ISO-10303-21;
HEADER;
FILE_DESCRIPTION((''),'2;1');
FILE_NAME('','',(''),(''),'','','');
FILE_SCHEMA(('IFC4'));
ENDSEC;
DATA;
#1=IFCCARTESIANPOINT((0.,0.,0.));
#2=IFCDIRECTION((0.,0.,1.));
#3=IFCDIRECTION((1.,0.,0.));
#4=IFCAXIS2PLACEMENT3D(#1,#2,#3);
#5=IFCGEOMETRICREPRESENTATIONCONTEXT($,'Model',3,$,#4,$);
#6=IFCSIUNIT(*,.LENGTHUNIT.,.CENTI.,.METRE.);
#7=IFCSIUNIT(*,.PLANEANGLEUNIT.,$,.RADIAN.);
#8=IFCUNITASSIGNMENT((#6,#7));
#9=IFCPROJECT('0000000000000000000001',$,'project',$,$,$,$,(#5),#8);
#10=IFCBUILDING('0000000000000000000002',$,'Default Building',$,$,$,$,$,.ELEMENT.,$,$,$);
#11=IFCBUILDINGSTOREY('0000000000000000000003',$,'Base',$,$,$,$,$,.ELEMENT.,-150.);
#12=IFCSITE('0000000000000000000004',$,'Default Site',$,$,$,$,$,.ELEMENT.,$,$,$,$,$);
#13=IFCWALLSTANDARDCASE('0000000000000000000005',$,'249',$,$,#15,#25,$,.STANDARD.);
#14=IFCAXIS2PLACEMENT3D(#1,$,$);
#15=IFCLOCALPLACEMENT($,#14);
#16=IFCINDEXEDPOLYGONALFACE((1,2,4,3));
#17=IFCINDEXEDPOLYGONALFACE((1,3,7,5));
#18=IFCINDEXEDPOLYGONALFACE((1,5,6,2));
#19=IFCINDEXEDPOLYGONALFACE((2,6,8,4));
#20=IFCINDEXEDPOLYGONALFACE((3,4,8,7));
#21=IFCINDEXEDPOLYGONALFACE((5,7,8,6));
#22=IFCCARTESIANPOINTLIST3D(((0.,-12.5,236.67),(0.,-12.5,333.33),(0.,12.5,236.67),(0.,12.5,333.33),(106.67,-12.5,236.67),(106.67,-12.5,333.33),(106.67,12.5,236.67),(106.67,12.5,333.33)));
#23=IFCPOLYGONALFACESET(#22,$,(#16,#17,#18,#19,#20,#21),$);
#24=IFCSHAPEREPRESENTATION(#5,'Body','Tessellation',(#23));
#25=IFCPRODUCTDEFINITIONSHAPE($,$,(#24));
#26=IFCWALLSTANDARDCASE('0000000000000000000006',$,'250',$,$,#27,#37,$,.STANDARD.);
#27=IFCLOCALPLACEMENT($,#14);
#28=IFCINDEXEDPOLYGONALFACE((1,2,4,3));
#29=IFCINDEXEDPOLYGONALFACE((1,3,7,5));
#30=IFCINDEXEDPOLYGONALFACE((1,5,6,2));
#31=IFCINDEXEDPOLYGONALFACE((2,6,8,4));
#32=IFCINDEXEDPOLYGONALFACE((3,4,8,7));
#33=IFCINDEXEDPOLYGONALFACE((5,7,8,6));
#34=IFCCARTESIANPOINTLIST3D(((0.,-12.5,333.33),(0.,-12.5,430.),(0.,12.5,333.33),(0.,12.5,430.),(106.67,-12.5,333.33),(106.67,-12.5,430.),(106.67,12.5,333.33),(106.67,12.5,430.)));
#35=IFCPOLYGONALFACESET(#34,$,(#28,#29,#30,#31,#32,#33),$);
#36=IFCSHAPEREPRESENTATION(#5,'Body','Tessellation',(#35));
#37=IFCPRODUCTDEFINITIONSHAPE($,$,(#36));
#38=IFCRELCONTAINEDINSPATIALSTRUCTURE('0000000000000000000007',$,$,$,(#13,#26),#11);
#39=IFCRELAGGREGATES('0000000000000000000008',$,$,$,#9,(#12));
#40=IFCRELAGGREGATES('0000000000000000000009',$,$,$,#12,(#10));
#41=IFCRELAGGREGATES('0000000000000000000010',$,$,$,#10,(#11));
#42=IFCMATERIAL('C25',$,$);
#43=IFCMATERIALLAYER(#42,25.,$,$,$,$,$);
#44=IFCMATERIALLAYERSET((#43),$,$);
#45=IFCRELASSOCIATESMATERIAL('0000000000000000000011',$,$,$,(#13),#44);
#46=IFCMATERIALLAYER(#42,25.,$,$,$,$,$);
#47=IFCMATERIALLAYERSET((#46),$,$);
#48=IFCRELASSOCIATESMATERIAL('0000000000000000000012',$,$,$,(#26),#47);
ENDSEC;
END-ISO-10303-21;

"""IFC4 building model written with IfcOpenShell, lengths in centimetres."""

from ifc_helpers import new_model, si_unit, frame, origin_with_axes, origin_2d_with_axis, place, context, project, spatial, rectangle, extrude, material, layer, layer_set, layer_usage, element, save


model = new_model("IFC4")

# Units and contexts
model_context = context("Model", 3, world=origin_with_axes())
ifc_project = project(units=[si_unit("LENGTHUNIT", "METRE", prefix="CENTI"), si_unit("PLANEANGLEUNIT", "RADIAN")], contexts=[model_context])

# Site, building, storey
site = spatial("IfcSite", under=ifc_project, Name="Default Site", CompositionType="ELEMENT")
building = spatial("IfcBuilding", under=site, Name="Default Building", CompositionType="ELEMENT")
storey = spatial("IfcBuildingStorey", under=building, Name="Base", CompositionType="ELEMENT", Elevation=-150.0)

# Walls
ifc_material = material(Name="C25")
ifc_layer_1 = layer(ifc_material, 25.0)
ifc_layer_set_1 = layer_set([ifc_layer_1])
ifc_layer_usage_1 = layer_usage(ifc_layer_set_1, "AXIS2", "POSITIVE", -25.0)
wall_1_placement = place(None, frame((53.33, 0.0, 236.67), z_axis=(0.0, 0.0, 1.0), x_axis=(-1.0, 0.0, 0.0)))
element("IfcWallStandardCase", 1, at=wall_1_placement, inside=storey, material=ifc_layer_usage_1, Name="249", PredefinedType="STANDARD", context=model_context, shape_type="SweptSolid", body=[
    extrude(rectangle(XDim=106.67, YDim=25.0, at=origin_2d_with_axis()), origin_with_axes(), (0.0, 0.0, 1.0), 96.67),
])
ifc_layer_2 = layer(ifc_material, 25.0)
ifc_layer_set_2 = layer_set([ifc_layer_2])
ifc_layer_usage_2 = layer_usage(ifc_layer_set_2, "AXIS2", "POSITIVE", -25.0)
wall_2_placement = place(None, frame((53.33, 0.0, 333.33), z_axis=(0.0, 0.0, 1.0), x_axis=(-1.0, 0.0, 0.0)))
element("IfcWallStandardCase", 2, at=wall_2_placement, inside=storey, material=ifc_layer_usage_2, Name="250", PredefinedType="STANDARD", context=model_context, shape_type="SweptSolid", body=[
    extrude(rectangle(XDim=106.67, YDim=25.0, at=origin_2d_with_axis()), origin_with_axes(), (0.0, 0.0, 1.0), 96.67),
])

save(model, "model.ifc")
